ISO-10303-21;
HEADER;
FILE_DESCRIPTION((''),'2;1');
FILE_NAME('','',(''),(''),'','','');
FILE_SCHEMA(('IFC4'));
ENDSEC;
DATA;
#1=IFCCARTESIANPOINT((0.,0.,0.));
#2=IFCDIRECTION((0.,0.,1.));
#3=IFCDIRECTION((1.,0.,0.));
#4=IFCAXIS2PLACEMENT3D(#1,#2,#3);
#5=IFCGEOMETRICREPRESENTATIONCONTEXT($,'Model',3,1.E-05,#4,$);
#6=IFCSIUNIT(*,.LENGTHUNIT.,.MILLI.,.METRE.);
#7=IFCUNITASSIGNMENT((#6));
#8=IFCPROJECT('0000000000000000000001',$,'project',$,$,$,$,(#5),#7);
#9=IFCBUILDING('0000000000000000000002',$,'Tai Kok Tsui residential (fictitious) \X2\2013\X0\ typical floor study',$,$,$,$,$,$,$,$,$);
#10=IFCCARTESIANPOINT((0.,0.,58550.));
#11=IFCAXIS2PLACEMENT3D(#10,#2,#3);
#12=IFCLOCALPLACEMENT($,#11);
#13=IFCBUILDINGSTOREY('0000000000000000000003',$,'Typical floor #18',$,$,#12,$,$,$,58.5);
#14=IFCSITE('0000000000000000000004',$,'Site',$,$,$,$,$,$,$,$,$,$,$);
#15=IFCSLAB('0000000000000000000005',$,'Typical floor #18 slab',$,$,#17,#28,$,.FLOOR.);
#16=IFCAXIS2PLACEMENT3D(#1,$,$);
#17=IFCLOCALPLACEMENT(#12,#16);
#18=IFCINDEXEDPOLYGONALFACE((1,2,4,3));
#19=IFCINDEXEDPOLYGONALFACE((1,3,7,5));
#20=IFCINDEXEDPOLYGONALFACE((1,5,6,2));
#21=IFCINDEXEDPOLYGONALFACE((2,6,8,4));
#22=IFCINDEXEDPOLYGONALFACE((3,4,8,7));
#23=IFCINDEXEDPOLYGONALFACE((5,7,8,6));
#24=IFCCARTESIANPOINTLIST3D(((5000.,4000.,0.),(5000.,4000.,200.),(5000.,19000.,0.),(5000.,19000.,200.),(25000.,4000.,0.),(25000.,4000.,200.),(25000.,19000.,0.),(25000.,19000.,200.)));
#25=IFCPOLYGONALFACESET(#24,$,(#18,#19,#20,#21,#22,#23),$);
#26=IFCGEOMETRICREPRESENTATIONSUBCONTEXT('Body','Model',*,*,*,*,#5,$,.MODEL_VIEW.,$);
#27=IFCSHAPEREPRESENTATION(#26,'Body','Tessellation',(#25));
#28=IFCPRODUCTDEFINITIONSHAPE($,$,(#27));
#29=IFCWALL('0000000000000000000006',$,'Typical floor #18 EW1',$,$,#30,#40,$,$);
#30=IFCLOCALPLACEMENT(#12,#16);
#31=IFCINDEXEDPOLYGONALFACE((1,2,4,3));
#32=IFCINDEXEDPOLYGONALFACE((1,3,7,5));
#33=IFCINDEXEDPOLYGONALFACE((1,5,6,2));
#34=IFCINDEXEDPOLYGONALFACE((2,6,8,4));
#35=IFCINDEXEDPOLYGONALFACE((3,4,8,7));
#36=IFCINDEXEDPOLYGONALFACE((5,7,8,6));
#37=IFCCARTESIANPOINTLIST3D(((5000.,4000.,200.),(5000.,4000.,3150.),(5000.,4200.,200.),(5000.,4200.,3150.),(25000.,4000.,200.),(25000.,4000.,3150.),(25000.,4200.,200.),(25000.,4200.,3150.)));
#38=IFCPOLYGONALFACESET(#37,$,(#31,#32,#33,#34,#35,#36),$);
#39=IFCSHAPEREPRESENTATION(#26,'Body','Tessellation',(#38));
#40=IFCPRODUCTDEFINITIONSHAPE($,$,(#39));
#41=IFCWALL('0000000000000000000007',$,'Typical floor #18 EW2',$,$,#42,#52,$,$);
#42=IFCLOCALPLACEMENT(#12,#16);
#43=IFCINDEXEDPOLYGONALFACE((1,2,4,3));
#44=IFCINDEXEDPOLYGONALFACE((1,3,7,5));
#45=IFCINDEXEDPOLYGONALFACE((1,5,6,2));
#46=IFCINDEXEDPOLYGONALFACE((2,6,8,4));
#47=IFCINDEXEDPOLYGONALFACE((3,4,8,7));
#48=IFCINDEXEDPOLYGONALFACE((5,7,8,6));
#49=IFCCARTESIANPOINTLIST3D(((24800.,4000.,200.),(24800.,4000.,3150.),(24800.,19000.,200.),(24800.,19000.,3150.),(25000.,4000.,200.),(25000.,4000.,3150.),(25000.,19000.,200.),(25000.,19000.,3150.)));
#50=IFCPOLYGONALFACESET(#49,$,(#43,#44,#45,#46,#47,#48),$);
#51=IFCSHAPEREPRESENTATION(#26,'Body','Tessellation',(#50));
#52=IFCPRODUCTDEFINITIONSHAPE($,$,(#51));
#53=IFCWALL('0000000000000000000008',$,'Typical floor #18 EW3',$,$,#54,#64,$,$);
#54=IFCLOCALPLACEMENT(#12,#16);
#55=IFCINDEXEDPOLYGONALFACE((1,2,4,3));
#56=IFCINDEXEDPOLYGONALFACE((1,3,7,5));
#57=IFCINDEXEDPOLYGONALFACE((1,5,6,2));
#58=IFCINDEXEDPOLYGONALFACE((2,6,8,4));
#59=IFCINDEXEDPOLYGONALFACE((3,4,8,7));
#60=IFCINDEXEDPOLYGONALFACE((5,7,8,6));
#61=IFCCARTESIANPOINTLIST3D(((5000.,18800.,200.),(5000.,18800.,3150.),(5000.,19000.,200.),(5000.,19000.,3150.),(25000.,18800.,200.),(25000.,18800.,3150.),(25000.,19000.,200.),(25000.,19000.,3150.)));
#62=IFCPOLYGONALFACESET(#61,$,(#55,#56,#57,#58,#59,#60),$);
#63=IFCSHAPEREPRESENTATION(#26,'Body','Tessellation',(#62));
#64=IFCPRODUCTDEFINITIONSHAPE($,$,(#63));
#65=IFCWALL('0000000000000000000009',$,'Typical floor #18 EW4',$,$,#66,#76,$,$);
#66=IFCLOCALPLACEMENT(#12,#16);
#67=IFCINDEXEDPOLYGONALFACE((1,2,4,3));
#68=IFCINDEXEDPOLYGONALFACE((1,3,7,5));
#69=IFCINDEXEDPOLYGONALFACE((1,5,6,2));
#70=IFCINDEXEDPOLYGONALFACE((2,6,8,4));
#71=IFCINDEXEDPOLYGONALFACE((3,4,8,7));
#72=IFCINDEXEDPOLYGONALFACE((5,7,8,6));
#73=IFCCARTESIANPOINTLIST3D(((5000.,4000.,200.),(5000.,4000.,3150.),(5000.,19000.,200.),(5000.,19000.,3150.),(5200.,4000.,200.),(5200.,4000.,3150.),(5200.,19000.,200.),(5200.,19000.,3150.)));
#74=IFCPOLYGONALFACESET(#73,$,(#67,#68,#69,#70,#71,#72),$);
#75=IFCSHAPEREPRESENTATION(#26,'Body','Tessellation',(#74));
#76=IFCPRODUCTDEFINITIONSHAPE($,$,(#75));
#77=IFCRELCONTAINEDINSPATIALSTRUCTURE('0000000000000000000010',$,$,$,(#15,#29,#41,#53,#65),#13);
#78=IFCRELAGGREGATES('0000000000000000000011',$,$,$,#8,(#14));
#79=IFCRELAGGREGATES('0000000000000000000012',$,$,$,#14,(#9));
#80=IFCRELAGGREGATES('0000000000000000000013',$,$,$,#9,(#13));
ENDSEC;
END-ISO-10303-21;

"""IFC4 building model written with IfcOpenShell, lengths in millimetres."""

from ifc_helpers import new_model, si_unit, frame, origin_with_axes, place, context, subcontext, project, spatial, indexed_curve, outline, extrude, element, save


model = new_model("IFC4")

# Units and contexts
model_context = context("Model", 3, precision=1e-05, world=origin_with_axes())
body_context = subcontext(model_context, "Body", "Model", "MODEL_VIEW")
ifc_project = project(units=[si_unit("LENGTHUNIT", "METRE", prefix="MILLI")], contexts=[model_context])

# Site, building, storey
site = spatial("IfcSite", under=ifc_project, Name="Site")
building = spatial("IfcBuilding", under=site, Name="Tai Kok Tsui residential (fictitious) – typical floor study")
storey_placement = place(None, frame((0.0, 0.0, 58550.0), z_axis=(0.0, 0.0, 1.0), x_axis=(1.0, 0.0, 0.0)))
storey = spatial("IfcBuildingStorey", under=building, at=storey_placement, Name="Typical floor #18", Elevation=58.5)

# Slab
slab_placement = place(storey_placement, origin_with_axes())
element("IfcSlab", 1, at=slab_placement, inside=storey, Name="Typical floor #18 slab", PredefinedType="FLOOR", context=body_context, shape_type="SweptSolid", body=[
    extrude(outline(indexed_curve([(5000.0, 4000.0), (25000.0, 4000.0), (25000.0, 19000.0), (5000.0, 19000.0)])), None, (0.0, 0.0, 1.0), 200.0),
])

# Walls
wall_1_placement = place(storey_placement, frame((5000.0, 4000.0, 200.0), z_axis=(0.0, 0.0, 1.0), x_axis=(1.0, 0.0, 0.0)))
element("IfcWall", 2, at=wall_1_placement, inside=storey, Name="Typical floor #18 EW1", context=body_context, shape_type="SweptSolid", body=[
    extrude(outline(indexed_curve([(0.0, 0.0), (0.0, 200.0), (20000.0, 200.0), (20000.0, 0.0), (0.0, 0.0)], self_intersect=False)), origin_with_axes(), (0.0, 0.0, 1.0), 2950.0),
])
wall_2_placement = place(storey_placement, frame((25000.0, 4000.0, 200.0), z_axis=(0.0, 0.0, 1.0), x_axis=(0.0, 1.0, 0.0)))
element("IfcWall", 3, at=wall_2_placement, inside=storey, Name="Typical floor #18 EW2", context=body_context, shape_type="SweptSolid", body=[
    extrude(outline(indexed_curve([(0.0, 0.0), (0.0, 200.0), (15000.0, 200.0), (15000.0, 0.0), (0.0, 0.0)], self_intersect=False)), origin_with_axes(), (0.0, 0.0, 1.0), 2950.0),
])
wall_3_placement = place(storey_placement, frame((25000.0, 19000.0, 200.0), z_axis=(0.0, 0.0, 1.0), x_axis=(-1.0, 0.0, 0.0)))
element("IfcWall", 4, at=wall_3_placement, inside=storey, Name="Typical floor #18 EW3", context=body_context, shape_type="SweptSolid", body=[
    extrude(outline(indexed_curve([(0.0, 0.0), (0.0, 200.0), (20000.0, 200.0), (20000.0, 0.0), (0.0, 0.0)], self_intersect=False)), origin_with_axes(), (0.0, 0.0, 1.0), 2950.0),
])
wall_4_placement = place(storey_placement, frame((5000.0, 19000.0, 200.0), z_axis=(0.0, 0.0, 1.0), x_axis=(0.0, -1.0, 0.0)))
element("IfcWall", 5, at=wall_4_placement, inside=storey, Name="Typical floor #18 EW4", context=body_context, shape_type="SweptSolid", body=[
    extrude(outline(indexed_curve([(0.0, 0.0), (0.0, 200.0), (15000.0, 200.0), (15000.0, 0.0), (0.0, 0.0)], self_intersect=False)), origin_with_axes(), (0.0, 0.0, 1.0), 2950.0),
])

save(model, "model.ifc")
